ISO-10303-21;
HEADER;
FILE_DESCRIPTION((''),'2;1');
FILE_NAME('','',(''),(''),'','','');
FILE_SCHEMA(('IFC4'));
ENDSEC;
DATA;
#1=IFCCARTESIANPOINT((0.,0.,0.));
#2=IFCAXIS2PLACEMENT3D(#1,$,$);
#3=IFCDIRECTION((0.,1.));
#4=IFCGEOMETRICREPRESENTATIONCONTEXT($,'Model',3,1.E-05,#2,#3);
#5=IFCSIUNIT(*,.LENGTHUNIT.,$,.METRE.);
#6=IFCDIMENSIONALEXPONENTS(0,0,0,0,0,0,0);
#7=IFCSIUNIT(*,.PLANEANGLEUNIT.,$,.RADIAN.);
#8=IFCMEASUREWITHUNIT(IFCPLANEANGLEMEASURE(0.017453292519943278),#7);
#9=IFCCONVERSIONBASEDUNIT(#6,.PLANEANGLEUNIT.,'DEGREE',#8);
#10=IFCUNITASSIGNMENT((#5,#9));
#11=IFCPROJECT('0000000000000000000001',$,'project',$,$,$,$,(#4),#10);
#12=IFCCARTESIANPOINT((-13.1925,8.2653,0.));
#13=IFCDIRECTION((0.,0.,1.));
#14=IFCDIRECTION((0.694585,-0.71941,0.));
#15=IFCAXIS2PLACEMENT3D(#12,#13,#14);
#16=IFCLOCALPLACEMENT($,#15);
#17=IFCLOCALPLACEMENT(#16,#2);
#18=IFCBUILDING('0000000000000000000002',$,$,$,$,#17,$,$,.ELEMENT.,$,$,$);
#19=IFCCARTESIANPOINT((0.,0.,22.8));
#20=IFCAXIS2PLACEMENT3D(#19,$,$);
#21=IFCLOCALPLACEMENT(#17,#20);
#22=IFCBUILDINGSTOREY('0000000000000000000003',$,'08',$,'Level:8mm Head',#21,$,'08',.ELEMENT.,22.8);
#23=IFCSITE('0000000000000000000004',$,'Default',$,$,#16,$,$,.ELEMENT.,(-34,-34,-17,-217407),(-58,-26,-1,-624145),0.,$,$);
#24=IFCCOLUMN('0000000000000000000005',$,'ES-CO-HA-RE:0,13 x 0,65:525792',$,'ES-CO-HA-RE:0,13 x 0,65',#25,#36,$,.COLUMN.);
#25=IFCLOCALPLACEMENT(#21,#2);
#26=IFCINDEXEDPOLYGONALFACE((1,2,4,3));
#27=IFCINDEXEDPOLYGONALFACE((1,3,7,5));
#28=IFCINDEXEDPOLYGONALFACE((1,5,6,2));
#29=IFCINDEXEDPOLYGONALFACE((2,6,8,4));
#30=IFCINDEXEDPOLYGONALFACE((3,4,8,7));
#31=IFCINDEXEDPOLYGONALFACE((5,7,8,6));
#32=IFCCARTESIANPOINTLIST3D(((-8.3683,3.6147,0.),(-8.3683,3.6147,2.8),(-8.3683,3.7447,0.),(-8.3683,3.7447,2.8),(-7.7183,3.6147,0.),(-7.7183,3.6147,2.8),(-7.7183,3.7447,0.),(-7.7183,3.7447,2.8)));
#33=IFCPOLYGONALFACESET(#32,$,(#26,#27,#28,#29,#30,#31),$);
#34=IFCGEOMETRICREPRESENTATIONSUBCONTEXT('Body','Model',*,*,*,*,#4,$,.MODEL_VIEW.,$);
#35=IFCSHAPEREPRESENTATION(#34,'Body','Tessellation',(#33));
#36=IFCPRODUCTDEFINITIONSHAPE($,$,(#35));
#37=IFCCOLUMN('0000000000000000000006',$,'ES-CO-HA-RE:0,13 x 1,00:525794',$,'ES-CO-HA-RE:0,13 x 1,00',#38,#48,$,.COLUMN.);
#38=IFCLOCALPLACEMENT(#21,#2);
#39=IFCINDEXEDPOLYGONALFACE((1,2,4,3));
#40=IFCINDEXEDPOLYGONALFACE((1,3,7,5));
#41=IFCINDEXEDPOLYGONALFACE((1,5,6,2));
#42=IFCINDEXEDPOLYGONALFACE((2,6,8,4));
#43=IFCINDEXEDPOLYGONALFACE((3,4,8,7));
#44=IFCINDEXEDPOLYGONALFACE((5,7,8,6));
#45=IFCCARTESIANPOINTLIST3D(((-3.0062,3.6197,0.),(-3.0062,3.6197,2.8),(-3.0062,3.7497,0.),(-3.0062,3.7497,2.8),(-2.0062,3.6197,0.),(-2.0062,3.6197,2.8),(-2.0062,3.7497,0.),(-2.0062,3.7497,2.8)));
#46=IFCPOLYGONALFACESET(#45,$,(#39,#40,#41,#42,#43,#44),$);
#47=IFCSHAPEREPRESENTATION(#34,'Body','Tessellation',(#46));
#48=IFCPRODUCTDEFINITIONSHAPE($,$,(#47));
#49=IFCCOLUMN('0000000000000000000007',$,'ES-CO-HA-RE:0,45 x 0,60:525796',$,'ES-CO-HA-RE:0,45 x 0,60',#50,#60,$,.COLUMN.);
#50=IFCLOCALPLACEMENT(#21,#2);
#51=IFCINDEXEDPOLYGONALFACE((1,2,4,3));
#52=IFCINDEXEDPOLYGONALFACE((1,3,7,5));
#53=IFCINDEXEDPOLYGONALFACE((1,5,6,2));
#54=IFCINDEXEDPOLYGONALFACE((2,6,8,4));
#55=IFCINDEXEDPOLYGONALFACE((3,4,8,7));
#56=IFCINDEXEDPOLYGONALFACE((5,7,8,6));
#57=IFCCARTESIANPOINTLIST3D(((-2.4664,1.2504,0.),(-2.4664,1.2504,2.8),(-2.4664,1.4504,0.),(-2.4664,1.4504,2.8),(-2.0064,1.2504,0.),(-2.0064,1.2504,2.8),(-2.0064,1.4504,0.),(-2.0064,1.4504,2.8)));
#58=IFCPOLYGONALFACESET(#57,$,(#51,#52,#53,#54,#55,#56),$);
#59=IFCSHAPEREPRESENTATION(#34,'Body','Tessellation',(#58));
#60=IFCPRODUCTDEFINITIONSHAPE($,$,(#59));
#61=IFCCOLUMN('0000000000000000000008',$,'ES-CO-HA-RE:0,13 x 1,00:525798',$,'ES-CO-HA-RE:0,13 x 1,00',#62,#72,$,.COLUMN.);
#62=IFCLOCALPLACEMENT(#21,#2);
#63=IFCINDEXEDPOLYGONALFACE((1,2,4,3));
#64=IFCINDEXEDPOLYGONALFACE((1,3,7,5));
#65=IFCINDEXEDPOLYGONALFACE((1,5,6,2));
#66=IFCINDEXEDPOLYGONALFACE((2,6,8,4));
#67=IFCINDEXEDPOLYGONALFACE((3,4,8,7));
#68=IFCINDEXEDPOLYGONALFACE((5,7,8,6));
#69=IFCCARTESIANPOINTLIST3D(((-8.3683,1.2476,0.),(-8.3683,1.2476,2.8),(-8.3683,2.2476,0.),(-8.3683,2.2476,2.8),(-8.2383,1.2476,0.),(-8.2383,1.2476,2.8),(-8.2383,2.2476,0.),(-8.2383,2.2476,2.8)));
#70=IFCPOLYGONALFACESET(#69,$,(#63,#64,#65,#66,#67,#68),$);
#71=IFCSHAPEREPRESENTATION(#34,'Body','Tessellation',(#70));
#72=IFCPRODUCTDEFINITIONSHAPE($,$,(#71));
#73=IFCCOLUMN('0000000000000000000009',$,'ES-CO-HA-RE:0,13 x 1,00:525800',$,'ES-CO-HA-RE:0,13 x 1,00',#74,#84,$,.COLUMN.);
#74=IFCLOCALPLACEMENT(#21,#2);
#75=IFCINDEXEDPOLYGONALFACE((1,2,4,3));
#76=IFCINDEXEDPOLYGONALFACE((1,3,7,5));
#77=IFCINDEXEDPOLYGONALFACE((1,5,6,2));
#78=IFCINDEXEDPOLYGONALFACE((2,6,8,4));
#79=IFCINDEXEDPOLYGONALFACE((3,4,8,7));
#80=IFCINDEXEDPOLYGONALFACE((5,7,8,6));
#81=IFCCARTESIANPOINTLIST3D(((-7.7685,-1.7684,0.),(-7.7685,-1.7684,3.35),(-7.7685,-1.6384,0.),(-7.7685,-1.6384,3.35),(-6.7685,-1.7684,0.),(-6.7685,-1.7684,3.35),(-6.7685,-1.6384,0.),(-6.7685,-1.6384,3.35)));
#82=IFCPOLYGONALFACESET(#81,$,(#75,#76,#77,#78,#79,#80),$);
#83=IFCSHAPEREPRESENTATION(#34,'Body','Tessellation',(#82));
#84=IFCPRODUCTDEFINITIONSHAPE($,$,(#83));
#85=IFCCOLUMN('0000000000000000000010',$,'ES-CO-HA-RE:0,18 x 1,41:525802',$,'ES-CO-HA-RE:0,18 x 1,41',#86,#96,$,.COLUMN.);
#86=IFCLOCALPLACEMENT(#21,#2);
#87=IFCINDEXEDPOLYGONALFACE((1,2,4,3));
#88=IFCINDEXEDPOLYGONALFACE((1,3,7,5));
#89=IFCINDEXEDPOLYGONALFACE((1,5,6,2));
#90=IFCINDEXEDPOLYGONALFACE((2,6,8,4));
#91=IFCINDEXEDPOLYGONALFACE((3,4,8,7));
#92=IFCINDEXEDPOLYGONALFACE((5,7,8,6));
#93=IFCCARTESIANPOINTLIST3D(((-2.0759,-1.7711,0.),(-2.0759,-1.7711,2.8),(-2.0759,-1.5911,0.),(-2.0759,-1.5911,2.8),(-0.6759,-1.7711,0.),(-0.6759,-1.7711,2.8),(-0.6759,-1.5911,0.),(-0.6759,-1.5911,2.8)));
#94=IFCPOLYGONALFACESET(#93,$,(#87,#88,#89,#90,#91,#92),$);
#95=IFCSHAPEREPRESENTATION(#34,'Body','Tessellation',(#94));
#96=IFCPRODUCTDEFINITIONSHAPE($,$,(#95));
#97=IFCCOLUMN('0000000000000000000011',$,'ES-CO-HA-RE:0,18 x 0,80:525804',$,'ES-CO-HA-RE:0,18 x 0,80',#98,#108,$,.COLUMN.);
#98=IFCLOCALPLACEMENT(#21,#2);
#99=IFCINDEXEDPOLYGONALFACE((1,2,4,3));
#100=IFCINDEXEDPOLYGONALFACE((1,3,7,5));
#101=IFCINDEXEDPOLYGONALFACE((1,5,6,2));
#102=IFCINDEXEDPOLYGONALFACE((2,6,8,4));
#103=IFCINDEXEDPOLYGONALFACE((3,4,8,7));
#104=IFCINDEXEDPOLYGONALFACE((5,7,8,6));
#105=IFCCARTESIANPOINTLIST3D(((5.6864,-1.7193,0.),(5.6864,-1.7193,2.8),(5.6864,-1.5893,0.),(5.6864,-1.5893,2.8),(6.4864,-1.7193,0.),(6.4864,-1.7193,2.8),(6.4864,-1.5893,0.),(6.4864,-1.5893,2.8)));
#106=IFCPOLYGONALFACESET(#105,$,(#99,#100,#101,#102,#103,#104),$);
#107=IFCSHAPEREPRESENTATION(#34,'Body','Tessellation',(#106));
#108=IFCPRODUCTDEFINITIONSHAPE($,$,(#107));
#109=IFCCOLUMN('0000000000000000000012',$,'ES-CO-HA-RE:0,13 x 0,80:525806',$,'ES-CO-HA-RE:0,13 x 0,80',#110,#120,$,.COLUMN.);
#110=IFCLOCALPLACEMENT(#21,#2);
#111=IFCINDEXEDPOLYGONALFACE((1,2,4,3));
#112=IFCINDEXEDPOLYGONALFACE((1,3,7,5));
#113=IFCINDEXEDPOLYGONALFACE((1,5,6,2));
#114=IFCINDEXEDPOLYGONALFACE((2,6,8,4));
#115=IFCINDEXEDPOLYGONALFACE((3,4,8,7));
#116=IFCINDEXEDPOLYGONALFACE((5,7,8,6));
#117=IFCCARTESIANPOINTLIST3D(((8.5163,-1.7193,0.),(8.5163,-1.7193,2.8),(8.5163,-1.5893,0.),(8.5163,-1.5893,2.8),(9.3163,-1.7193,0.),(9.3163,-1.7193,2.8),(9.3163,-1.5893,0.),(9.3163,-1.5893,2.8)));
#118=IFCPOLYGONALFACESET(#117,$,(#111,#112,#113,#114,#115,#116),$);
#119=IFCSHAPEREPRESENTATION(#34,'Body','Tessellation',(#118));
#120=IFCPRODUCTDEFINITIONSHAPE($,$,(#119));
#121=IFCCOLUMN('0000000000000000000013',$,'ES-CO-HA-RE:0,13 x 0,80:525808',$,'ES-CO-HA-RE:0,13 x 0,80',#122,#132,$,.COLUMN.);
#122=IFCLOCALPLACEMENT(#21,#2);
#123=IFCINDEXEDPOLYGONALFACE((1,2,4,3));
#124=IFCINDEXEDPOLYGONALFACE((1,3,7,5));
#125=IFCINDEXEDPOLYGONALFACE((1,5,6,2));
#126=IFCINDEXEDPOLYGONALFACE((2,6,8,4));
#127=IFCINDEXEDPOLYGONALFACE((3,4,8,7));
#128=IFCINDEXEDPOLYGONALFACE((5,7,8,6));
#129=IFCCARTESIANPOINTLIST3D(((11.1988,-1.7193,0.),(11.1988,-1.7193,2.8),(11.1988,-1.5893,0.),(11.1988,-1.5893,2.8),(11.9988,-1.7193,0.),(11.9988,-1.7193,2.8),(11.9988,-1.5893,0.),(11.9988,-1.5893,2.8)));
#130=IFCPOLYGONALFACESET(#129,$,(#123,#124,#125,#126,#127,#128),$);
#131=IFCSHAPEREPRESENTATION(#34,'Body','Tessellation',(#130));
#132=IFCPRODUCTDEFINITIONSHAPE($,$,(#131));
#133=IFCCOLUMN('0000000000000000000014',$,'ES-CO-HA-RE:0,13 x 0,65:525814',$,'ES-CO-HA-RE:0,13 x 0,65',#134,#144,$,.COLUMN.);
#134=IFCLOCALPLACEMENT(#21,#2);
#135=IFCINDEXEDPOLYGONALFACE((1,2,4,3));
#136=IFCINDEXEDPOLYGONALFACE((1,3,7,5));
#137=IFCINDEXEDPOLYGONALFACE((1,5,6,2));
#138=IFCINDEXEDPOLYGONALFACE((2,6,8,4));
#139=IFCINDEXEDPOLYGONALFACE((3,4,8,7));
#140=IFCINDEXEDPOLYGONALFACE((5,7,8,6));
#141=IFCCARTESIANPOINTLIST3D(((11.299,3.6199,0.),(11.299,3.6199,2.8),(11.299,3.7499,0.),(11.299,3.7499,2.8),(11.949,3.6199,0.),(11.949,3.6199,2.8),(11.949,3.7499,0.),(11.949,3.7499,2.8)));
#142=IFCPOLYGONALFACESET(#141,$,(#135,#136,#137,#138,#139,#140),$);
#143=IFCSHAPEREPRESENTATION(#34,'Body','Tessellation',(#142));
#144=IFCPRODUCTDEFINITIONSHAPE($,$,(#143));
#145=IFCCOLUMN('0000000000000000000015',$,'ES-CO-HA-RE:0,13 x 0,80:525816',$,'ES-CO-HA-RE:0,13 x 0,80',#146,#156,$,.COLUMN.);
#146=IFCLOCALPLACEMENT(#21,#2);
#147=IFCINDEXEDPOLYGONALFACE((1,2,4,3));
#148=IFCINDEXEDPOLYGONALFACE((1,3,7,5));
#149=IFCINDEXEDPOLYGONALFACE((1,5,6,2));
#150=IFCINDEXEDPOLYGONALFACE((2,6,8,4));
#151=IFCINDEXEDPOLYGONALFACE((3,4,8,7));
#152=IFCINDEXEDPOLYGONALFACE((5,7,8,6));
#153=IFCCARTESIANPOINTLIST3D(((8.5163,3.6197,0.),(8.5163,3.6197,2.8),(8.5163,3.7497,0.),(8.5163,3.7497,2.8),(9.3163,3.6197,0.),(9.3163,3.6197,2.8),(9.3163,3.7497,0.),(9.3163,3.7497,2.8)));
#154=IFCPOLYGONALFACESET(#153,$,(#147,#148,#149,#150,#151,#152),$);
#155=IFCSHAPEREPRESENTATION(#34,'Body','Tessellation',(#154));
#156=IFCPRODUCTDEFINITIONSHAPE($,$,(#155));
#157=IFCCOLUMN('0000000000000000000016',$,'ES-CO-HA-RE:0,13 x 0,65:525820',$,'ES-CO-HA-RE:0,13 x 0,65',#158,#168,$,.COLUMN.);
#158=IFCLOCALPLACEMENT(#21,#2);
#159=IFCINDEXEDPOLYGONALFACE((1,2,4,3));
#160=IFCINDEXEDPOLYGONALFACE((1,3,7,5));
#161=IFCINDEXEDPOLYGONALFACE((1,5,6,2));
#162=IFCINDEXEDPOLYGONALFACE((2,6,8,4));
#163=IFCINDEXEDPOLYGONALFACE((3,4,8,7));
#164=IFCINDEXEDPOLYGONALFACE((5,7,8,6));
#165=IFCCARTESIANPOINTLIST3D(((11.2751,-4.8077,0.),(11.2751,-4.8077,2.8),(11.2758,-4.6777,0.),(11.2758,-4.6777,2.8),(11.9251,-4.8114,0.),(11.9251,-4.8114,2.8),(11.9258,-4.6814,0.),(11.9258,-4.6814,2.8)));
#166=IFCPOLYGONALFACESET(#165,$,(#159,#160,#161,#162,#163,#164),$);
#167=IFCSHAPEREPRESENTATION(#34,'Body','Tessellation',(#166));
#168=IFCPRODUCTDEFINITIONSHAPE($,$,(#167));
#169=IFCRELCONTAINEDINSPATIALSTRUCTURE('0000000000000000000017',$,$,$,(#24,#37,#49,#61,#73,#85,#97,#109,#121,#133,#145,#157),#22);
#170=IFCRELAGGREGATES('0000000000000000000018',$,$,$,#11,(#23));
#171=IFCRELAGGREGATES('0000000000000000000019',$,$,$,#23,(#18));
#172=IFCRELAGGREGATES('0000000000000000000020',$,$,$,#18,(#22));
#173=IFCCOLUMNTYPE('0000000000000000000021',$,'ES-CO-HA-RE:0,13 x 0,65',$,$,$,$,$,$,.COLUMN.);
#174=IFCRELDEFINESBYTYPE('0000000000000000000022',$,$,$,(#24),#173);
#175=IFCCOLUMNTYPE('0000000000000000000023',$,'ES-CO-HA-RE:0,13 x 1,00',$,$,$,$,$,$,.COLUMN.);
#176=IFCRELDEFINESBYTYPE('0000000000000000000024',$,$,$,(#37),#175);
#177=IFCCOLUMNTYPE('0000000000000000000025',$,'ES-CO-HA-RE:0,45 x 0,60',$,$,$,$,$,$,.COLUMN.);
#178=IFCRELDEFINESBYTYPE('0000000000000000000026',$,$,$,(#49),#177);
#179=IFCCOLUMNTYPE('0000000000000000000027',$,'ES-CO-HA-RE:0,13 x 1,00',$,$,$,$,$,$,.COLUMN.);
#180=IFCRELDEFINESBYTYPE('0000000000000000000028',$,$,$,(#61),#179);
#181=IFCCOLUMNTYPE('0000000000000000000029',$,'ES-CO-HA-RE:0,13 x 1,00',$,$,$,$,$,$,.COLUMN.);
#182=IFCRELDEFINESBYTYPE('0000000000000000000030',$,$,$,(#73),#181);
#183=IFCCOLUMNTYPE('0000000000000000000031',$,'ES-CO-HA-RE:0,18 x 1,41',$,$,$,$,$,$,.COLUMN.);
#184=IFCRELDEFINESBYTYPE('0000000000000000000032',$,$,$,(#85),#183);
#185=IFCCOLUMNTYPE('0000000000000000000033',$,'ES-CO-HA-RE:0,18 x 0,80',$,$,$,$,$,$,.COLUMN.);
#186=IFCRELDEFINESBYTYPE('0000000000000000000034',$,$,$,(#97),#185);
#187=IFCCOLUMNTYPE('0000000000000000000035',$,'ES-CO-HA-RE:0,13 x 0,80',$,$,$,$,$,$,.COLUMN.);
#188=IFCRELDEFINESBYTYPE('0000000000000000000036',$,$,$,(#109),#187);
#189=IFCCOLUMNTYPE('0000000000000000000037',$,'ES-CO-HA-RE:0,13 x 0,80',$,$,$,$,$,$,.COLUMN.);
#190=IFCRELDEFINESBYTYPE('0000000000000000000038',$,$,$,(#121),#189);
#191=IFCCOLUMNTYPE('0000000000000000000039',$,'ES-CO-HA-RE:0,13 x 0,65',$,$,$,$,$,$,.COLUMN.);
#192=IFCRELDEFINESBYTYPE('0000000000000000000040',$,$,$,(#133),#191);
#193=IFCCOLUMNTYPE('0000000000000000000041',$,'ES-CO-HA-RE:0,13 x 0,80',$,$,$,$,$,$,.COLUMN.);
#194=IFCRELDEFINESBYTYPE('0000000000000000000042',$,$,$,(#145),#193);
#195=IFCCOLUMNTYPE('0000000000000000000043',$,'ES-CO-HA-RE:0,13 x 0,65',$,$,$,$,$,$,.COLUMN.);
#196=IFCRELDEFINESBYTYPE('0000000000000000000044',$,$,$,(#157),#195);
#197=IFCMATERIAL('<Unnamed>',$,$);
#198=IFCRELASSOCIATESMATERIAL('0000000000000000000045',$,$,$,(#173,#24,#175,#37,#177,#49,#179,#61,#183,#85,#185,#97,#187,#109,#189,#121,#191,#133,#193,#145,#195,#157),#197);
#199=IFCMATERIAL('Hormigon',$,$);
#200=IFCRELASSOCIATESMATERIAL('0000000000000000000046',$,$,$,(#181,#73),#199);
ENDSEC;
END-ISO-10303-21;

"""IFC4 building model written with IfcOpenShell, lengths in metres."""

from ifc_helpers import new_model, entity, si_unit, converted_unit, direction, frame, origin, place, context, subcontext, project, spatial, indexed_curve, outline, extrude, source, transform, mapped, material, type_object, type_shapes, element, save


model = new_model("IFC4")

# Units and contexts
model_context = context("Model", 3, precision=1e-05, world=origin(), true_north=direction((0.0, 1.0)))
body_context = subcontext(model_context, "Body", "Model", "MODEL_VIEW")
ifc_project = project(units=[si_unit("LENGTHUNIT", "METRE"), converted_unit("PLANEANGLEUNIT", "DEGREE", entity("IfcPlaneAngleMeasure", 0.017453292519943278), si_unit("PLANEANGLEUNIT", "RADIAN"), dimensions=[0, 0, 0, 0, 0, 0, 0])], contexts=[model_context])

# Site, building, storey
site_placement = place(None, frame((-13.1925, 8.2653, 0.0), z_axis=(0.0, 0.0, 1.0), x_axis=(0.694585, -0.71941, 0.0)))
site = spatial("IfcSite", under=ifc_project, at=site_placement, Name="Default", CompositionType="ELEMENT", RefLatitude=(-34, -34, -17, -217407), RefLongitude=(-58, -26, -1, -624145), RefElevation=0.0)
building_placement = place(site_placement, origin())
building = spatial("IfcBuilding", under=site, at=building_placement, CompositionType="ELEMENT")
storey_placement = place(building_placement, frame((0.0, 0.0, 22.8)))
storey = spatial("IfcBuildingStorey", under=building, at=storey_placement, Name="08", ObjectType="Level:8mm Head", LongName="08", CompositionType="ELEMENT", Elevation=22.8)

# Columns
ifc_material_1 = material(Name="<Unnamed>")
column_type_1 = type_object("IfcColumnType", Name="ES-CO-HA-RE:0,13 x 0,65", PredefinedType="COLUMN", material=ifc_material_1)
shared_shape_1 = source(origin(), body_context, "Body", "SweptSolid", [
    extrude(outline(indexed_curve([(-0.325, -0.065), (0.325, -0.065), (0.325, 0.065), (-0.325, 0.065), (-0.325, -0.065)], self_intersect=False)), frame((-8.0433, 3.6797, 22.8), z_axis=(0.0, 0.0, 1.0), x_axis=(-1.0, 0.0, 0.0)), (0.0, 0.0, 1.0), 2.8),
])
type_shapes(column_type_1, [shared_shape_1])
column_1_placement = place(storey_placement, frame((0.0, 0.0, -22.8)))
element("IfcColumn", 1, at=column_1_placement, inside=storey, type_object=column_type_1, material=ifc_material_1, Name="ES-CO-HA-RE:0,13 x 0,65:525792", ObjectType="ES-CO-HA-RE:0,13 x 0,65", PredefinedType="COLUMN", context=body_context, shape_type="MappedRepresentation", body=[
    mapped(shared_shape_1, transform((0.0, 0.0, 0.0), scale=1.0)),
])
column_type_2 = type_object("IfcColumnType", Name="ES-CO-HA-RE:0,13 x 1,00", PredefinedType="COLUMN", material=ifc_material_1)
shared_shape_2 = source(origin(), body_context, "Body", "SweptSolid", [
    extrude(outline(indexed_curve([(-0.5, -0.065), (0.5, -0.065), (0.5, 0.065), (-0.5, 0.065), (-0.5, -0.065)], self_intersect=False)), frame((-2.5062, 3.6847, 22.8), z_axis=(0.0, 0.0, 1.0), x_axis=(-1.0, 0.0, 0.0)), (0.0, 0.0, 1.0), 2.8),
])
type_shapes(column_type_2, [shared_shape_2])
column_2_placement = place(storey_placement, frame((0.0, 0.0, -22.8)))
element("IfcColumn", 2, at=column_2_placement, inside=storey, type_object=column_type_2, material=ifc_material_1, Name="ES-CO-HA-RE:0,13 x 1,00:525794", ObjectType="ES-CO-HA-RE:0,13 x 1,00", PredefinedType="COLUMN", context=body_context, shape_type="MappedRepresentation", body=[
    mapped(shared_shape_2, transform((0.0, 0.0, 0.0), scale=1.0)),
])
column_type_3 = type_object("IfcColumnType", Name="ES-CO-HA-RE:0,45 x 0,60", PredefinedType="COLUMN", material=ifc_material_1)
shared_shape_3 = source(origin(), body_context, "Body", "SweptSolid", [
    extrude(outline(indexed_curve([(-0.23, -0.1), (0.23, -0.1), (0.23, 0.1), (-0.23, 0.1), (-0.23, -0.1)], self_intersect=False)), frame((-2.2364, 1.3504, 22.8), z_axis=(0.0, 0.0, 1.0), x_axis=(-1.0, 0.0, 0.0)), (0.0, 0.0, 1.0), 2.8),
])
type_shapes(column_type_3, [shared_shape_3])
column_3_placement = place(storey_placement, frame((0.0, 0.0, -22.8)))
element("IfcColumn", 3, at=column_3_placement, inside=storey, type_object=column_type_3, material=ifc_material_1, Name="ES-CO-HA-RE:0,45 x 0,60:525796", ObjectType="ES-CO-HA-RE:0,45 x 0,60", PredefinedType="COLUMN", context=body_context, shape_type="MappedRepresentation", body=[
    mapped(shared_shape_3, transform((0.0, 0.0, 0.0), scale=1.0)),
])
column_type_4 = type_object("IfcColumnType", Name="ES-CO-HA-RE:0,13 x 1,00", PredefinedType="COLUMN", material=ifc_material_1)
shared_shape_4 = source(origin(), body_context, "Body", "SweptSolid", [
    extrude(outline(indexed_curve([(-0.5, -0.065), (0.5, -0.065), (0.5, 0.065), (-0.5, 0.065), (-0.5, -0.065)], self_intersect=False)), frame((-8.3033, 1.7476, 22.8), z_axis=(0.0, 0.0, 1.0), x_axis=(0.0, -1.0, 0.0)), (0.0, 0.0, 1.0), 2.8),
])
type_shapes(column_type_4, [shared_shape_4])
column_4_placement = place(storey_placement, frame((0.0, 0.0, -22.8)))
element("IfcColumn", 4, at=column_4_placement, inside=storey, type_object=column_type_4, material=ifc_material_1, Name="ES-CO-HA-RE:0,13 x 1,00:525798", ObjectType="ES-CO-HA-RE:0,13 x 1,00", PredefinedType="COLUMN", context=body_context, shape_type="MappedRepresentation", body=[
    mapped(shared_shape_4, transform((0.0, 0.0, 0.0), scale=1.0)),
])
ifc_material_2 = material(Name="Hormigon")
column_type_5 = type_object("IfcColumnType", Name="ES-CO-HA-RE:0,13 x 1,00", PredefinedType="COLUMN", material=ifc_material_2)
shared_shape_5 = source(origin(), body_context, "Body", "SweptSolid", [
    extrude(outline(indexed_curve([(-0.5, -0.065), (0.5, -0.065), (0.5, 0.065), (-0.5, 0.065), (-0.5, -0.065)], self_intersect=False)), frame((-7.2685, -1.7034, 22.8), z_axis=(0.0, 0.0, 1.0), x_axis=(-1.0, 0.0, 0.0)), (0.0, 0.0, 1.0), 3.35),
])
type_shapes(column_type_5, [shared_shape_5])
column_5_placement = place(storey_placement, frame((0.0, 0.0, -22.8)))
element("IfcColumn", 5, at=column_5_placement, inside=storey, type_object=column_type_5, material=ifc_material_2, Name="ES-CO-HA-RE:0,13 x 1,00:525800", ObjectType="ES-CO-HA-RE:0,13 x 1,00", PredefinedType="COLUMN", context=body_context, shape_type="MappedRepresentation", body=[
    mapped(shared_shape_5, transform((0.0, 0.0, 0.0), scale=1.0)),
])
column_type_6 = type_object("IfcColumnType", Name="ES-CO-HA-RE:0,18 x 1,41", PredefinedType="COLUMN", material=ifc_material_1)
shared_shape_6 = source(origin(), body_context, "Body", "SweptSolid", [
    extrude(outline(indexed_curve([(-0.7, -0.09), (0.7, -0.09), (0.7, 0.09), (-0.7, 0.09), (-0.7, -0.09)], self_intersect=False)), frame((-1.3759, -1.6811, 22.8), z_axis=(0.0, 0.0, 1.0), x_axis=(-1.0, 0.0, 0.0)), (0.0, 0.0, 1.0), 2.8),
])
type_shapes(column_type_6, [shared_shape_6])
column_6_placement = place(storey_placement, frame((0.0, 0.0, -22.8)))
element("IfcColumn", 6, at=column_6_placement, inside=storey, type_object=column_type_6, material=ifc_material_1, Name="ES-CO-HA-RE:0,18 x 1,41:525802", ObjectType="ES-CO-HA-RE:0,18 x 1,41", PredefinedType="COLUMN", context=body_context, shape_type="MappedRepresentation", body=[
    mapped(shared_shape_6, transform((0.0, 0.0, 0.0), scale=1.0)),
])
column_type_7 = type_object("IfcColumnType", Name="ES-CO-HA-RE:0,18 x 0,80", PredefinedType="COLUMN", material=ifc_material_1)
shared_shape_7 = source(origin(), body_context, "Body", "SweptSolid", [
    extrude(outline(indexed_curve([(-0.4, -0.065), (0.4, -0.065), (0.4, 0.065), (-0.4, 0.065), (-0.4, -0.065)], self_intersect=False)), frame((6.0864, -1.6543, 22.8), z_axis=(0.0, 0.0, 1.0), x_axis=(-1.0, 0.0, 0.0)), (0.0, 0.0, 1.0), 2.8),
])
type_shapes(column_type_7, [shared_shape_7])
column_7_placement = place(storey_placement, frame((0.0, 0.0, -22.8)))
element("IfcColumn", 7, at=column_7_placement, inside=storey, type_object=column_type_7, material=ifc_material_1, Name="ES-CO-HA-RE:0,18 x 0,80:525804", ObjectType="ES-CO-HA-RE:0,18 x 0,80", PredefinedType="COLUMN", context=body_context, shape_type="MappedRepresentation", body=[
    mapped(shared_shape_7, transform((0.0, 0.0, 0.0), scale=1.0)),
])
column_type_8 = type_object("IfcColumnType", Name="ES-CO-HA-RE:0,13 x 0,80", PredefinedType="COLUMN", material=ifc_material_1)
shared_shape_8 = source(origin(), body_context, "Body", "SweptSolid", [
    extrude(outline(indexed_curve([(-0.4, -0.065), (0.4, -0.065), (0.4, 0.065), (-0.4, 0.065), (-0.4, -0.065)], self_intersect=False)), frame((8.9163, -1.6543, 22.8), z_axis=(0.0, 0.0, 1.0), x_axis=(-1.0, 0.0, 0.0)), (0.0, 0.0, 1.0), 2.8),
])
type_shapes(column_type_8, [shared_shape_8])
column_8_placement = place(storey_placement, frame((0.0, 0.0, -22.8)))
element("IfcColumn", 8, at=column_8_placement, inside=storey, type_object=column_type_8, material=ifc_material_1, Name="ES-CO-HA-RE:0,13 x 0,80:525806", ObjectType="ES-CO-HA-RE:0,13 x 0,80", PredefinedType="COLUMN", context=body_context, shape_type="MappedRepresentation", body=[
    mapped(shared_shape_8, transform((0.0, 0.0, 0.0), scale=1.0)),
])
column_type_9 = type_object("IfcColumnType", Name="ES-CO-HA-RE:0,13 x 0,80", PredefinedType="COLUMN", material=ifc_material_1)
shared_shape_9 = source(origin(), body_context, "Body", "SweptSolid", [
    extrude(outline(indexed_curve([(-0.4, -0.065), (0.4, -0.065), (0.4, 0.065), (-0.4, 0.065), (-0.4, -0.065)], self_intersect=False)), frame((11.5988, -1.6543, 22.8), z_axis=(0.0, 0.0, 1.0), x_axis=(-1.0, 0.0, 0.0)), (0.0, 0.0, 1.0), 2.8),
])
type_shapes(column_type_9, [shared_shape_9])
column_9_placement = place(storey_placement, frame((0.0, 0.0, -22.8)))
element("IfcColumn", 9, at=column_9_placement, inside=storey, type_object=column_type_9, material=ifc_material_1, Name="ES-CO-HA-RE:0,13 x 0,80:525808", ObjectType="ES-CO-HA-RE:0,13 x 0,80", PredefinedType="COLUMN", context=body_context, shape_type="MappedRepresentation", body=[
    mapped(shared_shape_9, transform((0.0, 0.0, 0.0), scale=1.0)),
])
column_type_10 = type_object("IfcColumnType", Name="ES-CO-HA-RE:0,13 x 0,65", PredefinedType="COLUMN", material=ifc_material_1)
shared_shape_10 = source(origin(), body_context, "Body", "SweptSolid", [
    extrude(outline(indexed_curve([(-0.325, -0.065), (0.325, -0.065), (0.325, 0.065), (-0.325, 0.065), (-0.325, -0.065)], self_intersect=False)), frame((11.624, 3.6849, 22.8), z_axis=(0.0, 0.0, 1.0), x_axis=(-1.0, 0.0, 0.0)), (0.0, 0.0, 1.0), 2.8),
])
type_shapes(column_type_10, [shared_shape_10])
column_10_placement = place(storey_placement, frame((0.0, 0.0, -22.8)))
element("IfcColumn", 10, at=column_10_placement, inside=storey, type_object=column_type_10, material=ifc_material_1, Name="ES-CO-HA-RE:0,13 x 0,65:525814", ObjectType="ES-CO-HA-RE:0,13 x 0,65", PredefinedType="COLUMN", context=body_context, shape_type="MappedRepresentation", body=[
    mapped(shared_shape_10, transform((0.0, 0.0, 0.0), scale=1.0)),
])
column_type_11 = type_object("IfcColumnType", Name="ES-CO-HA-RE:0,13 x 0,80", PredefinedType="COLUMN", material=ifc_material_1)
shared_shape_11 = source(origin(), body_context, "Body", "SweptSolid", [
    extrude(outline(indexed_curve([(-0.4, -0.065), (0.4, -0.065), (0.4, 0.065), (-0.4, 0.065), (-0.4, -0.065)], self_intersect=False)), frame((8.9163, 3.6847, 22.8), z_axis=(0.0, 0.0, 1.0), x_axis=(-1.0, 0.0, 0.0)), (0.0, 0.0, 1.0), 2.8),
])
type_shapes(column_type_11, [shared_shape_11])
column_11_placement = place(storey_placement, frame((0.0, 0.0, -22.8)))
element("IfcColumn", 11, at=column_11_placement, inside=storey, type_object=column_type_11, material=ifc_material_1, Name="ES-CO-HA-RE:0,13 x 0,80:525816", ObjectType="ES-CO-HA-RE:0,13 x 0,80", PredefinedType="COLUMN", context=body_context, shape_type="MappedRepresentation", body=[
    mapped(shared_shape_11, transform((0.0, 0.0, 0.0), scale=1.0)),
])
column_type_12 = type_object("IfcColumnType", Name="ES-CO-HA-RE:0,13 x 0,65", PredefinedType="COLUMN", material=ifc_material_1)
shared_shape_12 = source(origin(), body_context, "Body", "SweptSolid", [
    extrude(outline(indexed_curve([(-0.325, -0.065), (0.325, -0.065), (0.325, 0.065), (-0.325, 0.065), (-0.325, -0.065)], self_intersect=False)), frame((11.6005, -4.7445, 22.8), z_axis=(0.0, 0.0, 1.0), x_axis=(-0.999984, 0.005619, 0.0)), (0.0, 0.0, 1.0), 2.8),
])
type_shapes(column_type_12, [shared_shape_12])
column_12_placement = place(storey_placement, frame((0.0, 0.0, -22.8)))
element("IfcColumn", 12, at=column_12_placement, inside=storey, type_object=column_type_12, material=ifc_material_1, Name="ES-CO-HA-RE:0,13 x 0,65:525820", ObjectType="ES-CO-HA-RE:0,13 x 0,65", PredefinedType="COLUMN", context=body_context, shape_type="MappedRepresentation", body=[
    mapped(shared_shape_12, transform((0.0, 0.0, 0.0), scale=1.0)),
])

save(model, "model.ifc")
